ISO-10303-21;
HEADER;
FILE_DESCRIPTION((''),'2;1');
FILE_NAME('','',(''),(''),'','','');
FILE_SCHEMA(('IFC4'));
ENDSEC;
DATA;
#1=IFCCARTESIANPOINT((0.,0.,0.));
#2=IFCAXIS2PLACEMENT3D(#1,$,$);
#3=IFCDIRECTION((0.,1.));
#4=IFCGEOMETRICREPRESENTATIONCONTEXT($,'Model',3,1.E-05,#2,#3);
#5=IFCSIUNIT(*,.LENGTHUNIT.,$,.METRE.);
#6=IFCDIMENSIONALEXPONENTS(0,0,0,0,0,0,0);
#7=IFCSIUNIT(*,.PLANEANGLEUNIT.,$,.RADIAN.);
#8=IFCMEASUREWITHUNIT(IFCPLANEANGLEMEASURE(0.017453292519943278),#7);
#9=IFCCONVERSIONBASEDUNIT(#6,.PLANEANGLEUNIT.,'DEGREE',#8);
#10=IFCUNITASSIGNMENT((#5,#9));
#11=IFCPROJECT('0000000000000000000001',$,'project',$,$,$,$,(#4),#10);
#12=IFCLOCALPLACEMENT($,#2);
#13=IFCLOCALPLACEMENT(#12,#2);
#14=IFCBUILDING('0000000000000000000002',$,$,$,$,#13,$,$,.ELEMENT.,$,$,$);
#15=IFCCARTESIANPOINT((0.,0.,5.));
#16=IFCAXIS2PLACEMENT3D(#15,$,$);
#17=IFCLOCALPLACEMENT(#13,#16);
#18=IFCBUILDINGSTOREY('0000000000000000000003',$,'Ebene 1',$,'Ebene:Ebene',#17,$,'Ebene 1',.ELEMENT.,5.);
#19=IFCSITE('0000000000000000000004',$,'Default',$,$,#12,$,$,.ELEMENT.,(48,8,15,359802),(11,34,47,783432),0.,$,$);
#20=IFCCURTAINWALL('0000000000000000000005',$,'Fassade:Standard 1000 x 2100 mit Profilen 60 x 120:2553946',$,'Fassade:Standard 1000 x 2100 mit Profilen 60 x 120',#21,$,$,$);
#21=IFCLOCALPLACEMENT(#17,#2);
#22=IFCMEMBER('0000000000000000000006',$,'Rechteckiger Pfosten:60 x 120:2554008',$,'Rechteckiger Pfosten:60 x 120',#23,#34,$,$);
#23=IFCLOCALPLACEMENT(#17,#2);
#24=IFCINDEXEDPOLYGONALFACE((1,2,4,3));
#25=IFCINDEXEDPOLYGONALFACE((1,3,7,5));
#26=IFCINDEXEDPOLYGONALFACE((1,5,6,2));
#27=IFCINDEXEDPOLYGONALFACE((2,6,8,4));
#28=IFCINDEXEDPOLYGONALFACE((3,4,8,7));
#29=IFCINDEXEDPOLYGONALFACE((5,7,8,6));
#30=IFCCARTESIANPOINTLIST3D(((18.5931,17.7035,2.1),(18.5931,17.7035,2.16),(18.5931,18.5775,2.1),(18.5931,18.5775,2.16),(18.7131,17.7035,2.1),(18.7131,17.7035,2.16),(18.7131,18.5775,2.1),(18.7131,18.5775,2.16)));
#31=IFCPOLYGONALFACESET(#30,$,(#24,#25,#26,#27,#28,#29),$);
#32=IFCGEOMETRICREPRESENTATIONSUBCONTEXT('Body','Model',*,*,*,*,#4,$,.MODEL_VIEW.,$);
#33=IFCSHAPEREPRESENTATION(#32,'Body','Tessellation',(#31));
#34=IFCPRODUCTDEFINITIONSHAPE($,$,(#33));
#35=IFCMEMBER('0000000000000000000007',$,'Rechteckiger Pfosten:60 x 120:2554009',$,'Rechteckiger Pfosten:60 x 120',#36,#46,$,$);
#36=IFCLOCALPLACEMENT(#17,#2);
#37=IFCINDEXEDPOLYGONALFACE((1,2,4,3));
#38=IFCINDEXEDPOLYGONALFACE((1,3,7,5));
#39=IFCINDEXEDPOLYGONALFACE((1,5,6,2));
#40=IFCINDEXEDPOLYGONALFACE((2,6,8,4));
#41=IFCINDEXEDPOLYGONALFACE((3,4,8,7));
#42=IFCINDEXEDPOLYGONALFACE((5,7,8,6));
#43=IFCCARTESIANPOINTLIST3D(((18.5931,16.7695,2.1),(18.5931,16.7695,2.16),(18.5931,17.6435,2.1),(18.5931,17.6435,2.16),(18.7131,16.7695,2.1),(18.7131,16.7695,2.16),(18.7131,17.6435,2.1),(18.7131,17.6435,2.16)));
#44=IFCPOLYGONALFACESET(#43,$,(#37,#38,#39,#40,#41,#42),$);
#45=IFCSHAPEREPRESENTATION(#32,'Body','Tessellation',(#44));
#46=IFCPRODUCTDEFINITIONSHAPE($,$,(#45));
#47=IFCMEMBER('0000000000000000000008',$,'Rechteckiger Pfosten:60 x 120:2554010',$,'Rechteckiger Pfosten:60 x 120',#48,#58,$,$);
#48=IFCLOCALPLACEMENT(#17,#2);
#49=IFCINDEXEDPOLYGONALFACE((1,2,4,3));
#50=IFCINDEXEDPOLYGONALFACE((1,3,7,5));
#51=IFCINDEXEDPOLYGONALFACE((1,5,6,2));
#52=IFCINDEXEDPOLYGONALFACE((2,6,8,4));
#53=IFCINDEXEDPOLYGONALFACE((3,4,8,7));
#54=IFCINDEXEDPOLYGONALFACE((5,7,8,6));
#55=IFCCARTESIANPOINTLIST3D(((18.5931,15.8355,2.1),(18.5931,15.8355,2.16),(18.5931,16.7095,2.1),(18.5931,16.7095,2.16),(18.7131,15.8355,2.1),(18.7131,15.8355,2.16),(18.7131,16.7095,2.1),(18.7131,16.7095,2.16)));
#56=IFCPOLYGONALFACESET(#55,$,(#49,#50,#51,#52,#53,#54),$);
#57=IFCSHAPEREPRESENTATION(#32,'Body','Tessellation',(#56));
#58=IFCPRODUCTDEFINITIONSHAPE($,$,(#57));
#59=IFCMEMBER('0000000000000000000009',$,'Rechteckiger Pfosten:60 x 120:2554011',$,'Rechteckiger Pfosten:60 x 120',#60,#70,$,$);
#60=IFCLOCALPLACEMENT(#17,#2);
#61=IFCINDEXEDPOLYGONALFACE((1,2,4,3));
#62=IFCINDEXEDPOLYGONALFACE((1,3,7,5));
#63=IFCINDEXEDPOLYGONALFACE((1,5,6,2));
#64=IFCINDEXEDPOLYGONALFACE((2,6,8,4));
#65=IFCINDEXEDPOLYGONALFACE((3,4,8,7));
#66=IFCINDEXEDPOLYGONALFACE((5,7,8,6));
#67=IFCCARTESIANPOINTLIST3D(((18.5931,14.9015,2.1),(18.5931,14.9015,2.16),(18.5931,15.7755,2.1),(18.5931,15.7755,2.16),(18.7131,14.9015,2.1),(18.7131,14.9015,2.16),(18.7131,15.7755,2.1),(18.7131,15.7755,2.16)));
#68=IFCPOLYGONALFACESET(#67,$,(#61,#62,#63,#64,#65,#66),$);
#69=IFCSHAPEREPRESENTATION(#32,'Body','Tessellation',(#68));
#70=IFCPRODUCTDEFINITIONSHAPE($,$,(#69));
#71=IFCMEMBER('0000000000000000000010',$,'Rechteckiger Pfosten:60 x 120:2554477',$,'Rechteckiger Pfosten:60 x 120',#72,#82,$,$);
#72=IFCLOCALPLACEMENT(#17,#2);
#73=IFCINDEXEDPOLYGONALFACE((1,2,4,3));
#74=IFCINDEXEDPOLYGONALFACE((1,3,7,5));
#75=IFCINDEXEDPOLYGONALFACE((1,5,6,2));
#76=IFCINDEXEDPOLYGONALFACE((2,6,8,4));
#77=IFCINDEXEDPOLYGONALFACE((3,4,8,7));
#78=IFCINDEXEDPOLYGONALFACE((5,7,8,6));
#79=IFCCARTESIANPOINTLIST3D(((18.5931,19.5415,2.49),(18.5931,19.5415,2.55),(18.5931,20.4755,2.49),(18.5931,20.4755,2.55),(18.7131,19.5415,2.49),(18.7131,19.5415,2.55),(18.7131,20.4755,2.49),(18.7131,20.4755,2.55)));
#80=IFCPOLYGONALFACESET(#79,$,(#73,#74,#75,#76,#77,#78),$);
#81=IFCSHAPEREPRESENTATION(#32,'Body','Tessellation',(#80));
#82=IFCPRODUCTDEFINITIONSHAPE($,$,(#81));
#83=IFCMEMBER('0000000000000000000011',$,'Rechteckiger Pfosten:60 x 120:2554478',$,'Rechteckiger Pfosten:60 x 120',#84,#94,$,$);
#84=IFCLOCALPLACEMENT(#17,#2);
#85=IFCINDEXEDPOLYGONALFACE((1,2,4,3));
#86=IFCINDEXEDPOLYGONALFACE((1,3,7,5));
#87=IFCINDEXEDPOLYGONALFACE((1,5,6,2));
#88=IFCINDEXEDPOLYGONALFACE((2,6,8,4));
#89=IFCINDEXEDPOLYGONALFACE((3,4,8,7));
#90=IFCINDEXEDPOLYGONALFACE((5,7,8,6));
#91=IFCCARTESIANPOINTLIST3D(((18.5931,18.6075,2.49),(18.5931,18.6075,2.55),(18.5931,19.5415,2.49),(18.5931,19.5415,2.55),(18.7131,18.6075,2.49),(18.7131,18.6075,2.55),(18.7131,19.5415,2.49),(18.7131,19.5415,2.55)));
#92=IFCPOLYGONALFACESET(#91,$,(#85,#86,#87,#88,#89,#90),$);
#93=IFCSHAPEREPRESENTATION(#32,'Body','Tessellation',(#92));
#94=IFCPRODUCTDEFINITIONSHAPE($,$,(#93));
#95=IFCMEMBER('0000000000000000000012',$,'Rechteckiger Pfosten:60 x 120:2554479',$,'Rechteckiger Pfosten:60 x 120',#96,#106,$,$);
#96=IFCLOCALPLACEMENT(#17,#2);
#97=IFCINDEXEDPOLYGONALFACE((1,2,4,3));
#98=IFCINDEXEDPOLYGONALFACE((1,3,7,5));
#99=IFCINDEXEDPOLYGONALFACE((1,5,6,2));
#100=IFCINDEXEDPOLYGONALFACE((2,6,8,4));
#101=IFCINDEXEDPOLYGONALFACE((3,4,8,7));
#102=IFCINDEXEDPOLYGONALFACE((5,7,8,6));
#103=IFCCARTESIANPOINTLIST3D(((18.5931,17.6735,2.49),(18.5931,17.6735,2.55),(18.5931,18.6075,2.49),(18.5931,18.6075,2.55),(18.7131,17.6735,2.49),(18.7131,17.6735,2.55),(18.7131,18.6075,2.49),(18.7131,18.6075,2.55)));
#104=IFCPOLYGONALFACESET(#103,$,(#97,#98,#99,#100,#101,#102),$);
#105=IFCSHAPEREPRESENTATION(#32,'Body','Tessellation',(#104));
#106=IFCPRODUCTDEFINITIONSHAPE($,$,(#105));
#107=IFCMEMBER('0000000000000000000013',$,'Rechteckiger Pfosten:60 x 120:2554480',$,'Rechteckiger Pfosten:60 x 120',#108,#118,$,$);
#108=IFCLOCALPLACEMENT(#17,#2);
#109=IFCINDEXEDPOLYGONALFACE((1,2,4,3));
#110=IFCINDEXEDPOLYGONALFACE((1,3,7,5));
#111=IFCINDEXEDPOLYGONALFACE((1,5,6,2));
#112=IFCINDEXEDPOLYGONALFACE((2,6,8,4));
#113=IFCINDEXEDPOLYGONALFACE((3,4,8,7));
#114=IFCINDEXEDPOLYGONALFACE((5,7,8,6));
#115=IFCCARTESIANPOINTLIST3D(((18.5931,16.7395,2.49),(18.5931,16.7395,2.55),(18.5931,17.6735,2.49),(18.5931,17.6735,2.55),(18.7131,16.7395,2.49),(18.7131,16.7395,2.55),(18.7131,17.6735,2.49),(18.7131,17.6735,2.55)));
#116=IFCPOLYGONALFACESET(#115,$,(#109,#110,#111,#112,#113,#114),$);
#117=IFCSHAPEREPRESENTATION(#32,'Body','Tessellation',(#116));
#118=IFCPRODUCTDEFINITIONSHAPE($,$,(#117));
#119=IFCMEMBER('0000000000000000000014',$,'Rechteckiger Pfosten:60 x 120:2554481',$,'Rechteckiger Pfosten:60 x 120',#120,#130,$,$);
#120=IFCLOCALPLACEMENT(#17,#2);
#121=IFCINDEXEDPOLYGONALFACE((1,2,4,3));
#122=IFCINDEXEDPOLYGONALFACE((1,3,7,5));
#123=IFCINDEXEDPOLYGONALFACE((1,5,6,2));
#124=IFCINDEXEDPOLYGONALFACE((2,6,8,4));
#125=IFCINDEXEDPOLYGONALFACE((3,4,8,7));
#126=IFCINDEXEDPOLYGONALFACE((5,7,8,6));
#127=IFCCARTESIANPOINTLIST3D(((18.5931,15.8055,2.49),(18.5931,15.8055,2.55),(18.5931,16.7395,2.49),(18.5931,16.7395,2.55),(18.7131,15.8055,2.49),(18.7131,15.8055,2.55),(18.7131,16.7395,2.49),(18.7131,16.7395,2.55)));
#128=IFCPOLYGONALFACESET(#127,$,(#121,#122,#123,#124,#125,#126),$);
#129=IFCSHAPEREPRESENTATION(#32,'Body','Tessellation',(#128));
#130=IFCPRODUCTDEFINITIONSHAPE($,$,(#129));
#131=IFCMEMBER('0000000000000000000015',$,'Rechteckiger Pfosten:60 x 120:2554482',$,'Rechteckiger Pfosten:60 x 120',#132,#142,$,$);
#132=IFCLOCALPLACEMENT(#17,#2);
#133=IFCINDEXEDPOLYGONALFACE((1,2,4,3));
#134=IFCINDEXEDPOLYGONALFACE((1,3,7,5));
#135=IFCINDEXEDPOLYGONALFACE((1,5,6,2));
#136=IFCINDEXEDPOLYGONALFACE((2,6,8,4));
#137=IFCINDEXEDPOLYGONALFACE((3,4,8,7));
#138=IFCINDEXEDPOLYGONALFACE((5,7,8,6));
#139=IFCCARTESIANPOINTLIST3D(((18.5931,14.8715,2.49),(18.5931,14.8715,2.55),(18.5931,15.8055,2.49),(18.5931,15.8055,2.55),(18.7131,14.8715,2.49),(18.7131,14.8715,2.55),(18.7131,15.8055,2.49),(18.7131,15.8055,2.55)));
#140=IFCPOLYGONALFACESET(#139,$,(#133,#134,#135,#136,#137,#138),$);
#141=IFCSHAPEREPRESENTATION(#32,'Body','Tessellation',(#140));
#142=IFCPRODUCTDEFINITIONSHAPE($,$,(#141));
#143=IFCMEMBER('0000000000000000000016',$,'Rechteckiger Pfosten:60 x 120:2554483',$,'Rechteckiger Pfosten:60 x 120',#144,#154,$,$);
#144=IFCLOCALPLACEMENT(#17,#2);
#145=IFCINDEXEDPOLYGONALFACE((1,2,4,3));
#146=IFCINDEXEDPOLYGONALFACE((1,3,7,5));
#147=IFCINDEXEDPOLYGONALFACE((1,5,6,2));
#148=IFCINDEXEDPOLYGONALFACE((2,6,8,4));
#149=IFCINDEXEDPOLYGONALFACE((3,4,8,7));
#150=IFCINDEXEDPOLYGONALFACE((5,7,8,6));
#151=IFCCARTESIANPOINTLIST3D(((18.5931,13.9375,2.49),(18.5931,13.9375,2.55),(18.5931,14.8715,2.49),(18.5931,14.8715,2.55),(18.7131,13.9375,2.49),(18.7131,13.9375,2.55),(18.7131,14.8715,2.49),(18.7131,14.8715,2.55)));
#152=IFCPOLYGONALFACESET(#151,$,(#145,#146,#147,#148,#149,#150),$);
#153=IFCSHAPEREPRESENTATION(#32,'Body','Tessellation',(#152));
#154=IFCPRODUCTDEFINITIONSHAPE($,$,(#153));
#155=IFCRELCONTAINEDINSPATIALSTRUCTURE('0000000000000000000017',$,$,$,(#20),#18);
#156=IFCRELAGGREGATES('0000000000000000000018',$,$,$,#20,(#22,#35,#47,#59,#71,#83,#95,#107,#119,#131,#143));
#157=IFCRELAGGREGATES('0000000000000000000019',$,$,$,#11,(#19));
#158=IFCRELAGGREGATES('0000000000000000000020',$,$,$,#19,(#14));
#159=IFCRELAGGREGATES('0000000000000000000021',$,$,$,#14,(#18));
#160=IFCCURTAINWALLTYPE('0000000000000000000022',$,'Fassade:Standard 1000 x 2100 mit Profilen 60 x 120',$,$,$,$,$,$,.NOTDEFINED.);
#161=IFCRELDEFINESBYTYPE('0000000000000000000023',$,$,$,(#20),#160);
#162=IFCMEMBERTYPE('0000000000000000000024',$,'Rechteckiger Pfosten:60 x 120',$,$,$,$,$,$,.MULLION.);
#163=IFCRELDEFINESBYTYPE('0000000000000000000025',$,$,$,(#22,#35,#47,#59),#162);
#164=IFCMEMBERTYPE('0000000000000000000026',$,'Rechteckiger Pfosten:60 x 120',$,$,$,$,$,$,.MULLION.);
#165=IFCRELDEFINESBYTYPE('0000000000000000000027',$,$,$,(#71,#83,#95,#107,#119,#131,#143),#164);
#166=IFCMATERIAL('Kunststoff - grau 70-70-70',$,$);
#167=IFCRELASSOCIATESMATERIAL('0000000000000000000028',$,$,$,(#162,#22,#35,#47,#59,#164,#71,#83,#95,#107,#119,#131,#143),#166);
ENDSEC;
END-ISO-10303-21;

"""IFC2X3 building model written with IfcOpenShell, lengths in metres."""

from ifc_helpers import new_model, entity, si_unit, converted_unit, direction, frame, frame_2d, origin, origin_2d_with_axis, place, context, subcontext, project, spatial, rectangle, extrude, source, transform, mapped, material, type_object, type_shapes, element, aggregate, save


model = new_model("IFC2X3")

# Units and contexts
model_context = context("Model", 3, precision=1e-05, world=origin(), true_north=direction((0.0, 1.0)))
body_context = subcontext(model_context, "Body", "Model", "MODEL_VIEW")
ifc_project = project(units=[si_unit("LENGTHUNIT", "METRE"), converted_unit("PLANEANGLEUNIT", "DEGREE", entity("IfcPlaneAngleMeasure", 0.017453292519943278), si_unit("PLANEANGLEUNIT", "RADIAN"), dimensions=[0, 0, 0, 0, 0, 0, 0])], contexts=[model_context])

# Site, building, storey
site_placement = place(None, origin())
site = spatial("IfcSite", under=ifc_project, at=site_placement, Name="Default", CompositionType="ELEMENT", RefLatitude=(48, 8, 15, 359802), RefLongitude=(11, 34, 47, 783432), RefElevation=0.0)
building_placement = place(site_placement, origin())
building = spatial("IfcBuilding", under=site, at=building_placement, CompositionType="ELEMENT")
storey_placement = place(building_placement, frame((0.0, 0.0, 5.0)))
storey = spatial("IfcBuildingStorey", under=building, at=storey_placement, Name="Ebene 1", ObjectType="Ebene:Ebene", LongName="Ebene 1", CompositionType="ELEMENT", Elevation=5.0)

# Shared definitions
curtain_wall_type = type_object("IfcCurtainWallType", Name="Fassade:Standard 1000 x 2100 mit Profilen 60 x 120", PredefinedType="NOTDEFINED")
ifc_material_1 = material(Name="Kunststoff - grau 70-70-70")

# Curtain wall
curtain_wall_1_placement = place(storey_placement, frame((0.0, 0.0, -5.0)))
curtain_wall_1 = element("IfcCurtainWall", 1, at=curtain_wall_1_placement, inside=storey, type_object=curtain_wall_type, Name="Fassade:Standard 1000 x 2100 mit Profilen 60 x 120:2553946", ObjectType="Fassade:Standard 1000 x 2100 mit Profilen 60 x 120")

# Members
member_type_1 = type_object("IfcMemberType", Name="Rechteckiger Pfosten:60 x 120", PredefinedType="MULLION", material=ifc_material_1)
shared_shape_1 = source(origin(), body_context, "Body", "SweptSolid", [
    extrude(rectangle(XDim=0.06, YDim=0.12, at=frame_2d((0.0, 0.0), x_axis=(1.0, 0.0))), frame((0.0, 0.0, -0.874), z_axis=(0.0, 0.0, 1.0), x_axis=(-1.0, 0.0, 0.0)), (0.0, 0.0, 1.0), 0.874),
])
type_shapes(member_type_1, [shared_shape_1])
member_1_placement = place(curtain_wall_1_placement, frame((18.6531, 17.7035, 7.13), z_axis=(0.0, -1.0, 0.0), x_axis=(0.0, 0.0, 1.0)))
member_1 = element("IfcMember", 2, at=member_1_placement, type_object=member_type_1, material=ifc_material_1, Name="Rechteckiger Pfosten:60 x 120:2554008", ObjectType="Rechteckiger Pfosten:60 x 120", context=body_context, shape_type="MappedRepresentation", body=[
    mapped(shared_shape_1, transform((0.0, 0.0, 0.0), scale=1.0)),
])
member_2_placement = place(curtain_wall_1_placement, frame((18.6531, 16.7695, 7.13), z_axis=(0.0, -1.0, 0.0), x_axis=(0.0, 0.0, 1.0)))
member_2 = element("IfcMember", 3, at=member_2_placement, type_object=member_type_1, material=ifc_material_1, Name="Rechteckiger Pfosten:60 x 120:2554009", ObjectType="Rechteckiger Pfosten:60 x 120", context=body_context, shape_type="MappedRepresentation", body=[
    mapped(shared_shape_1, transform((0.0, 0.0, 0.0), scale=1.0)),
])
member_3_placement = place(curtain_wall_1_placement, frame((18.6531, 15.8355, 7.13), z_axis=(0.0, -1.0, 0.0), x_axis=(0.0, 0.0, 1.0)))
member_3 = element("IfcMember", 4, at=member_3_placement, type_object=member_type_1, material=ifc_material_1, Name="Rechteckiger Pfosten:60 x 120:2554010", ObjectType="Rechteckiger Pfosten:60 x 120", context=body_context, shape_type="MappedRepresentation", body=[
    mapped(shared_shape_1, transform((0.0, 0.0, 0.0), scale=1.0)),
])
member_4_placement = place(curtain_wall_1_placement, frame((18.6531, 14.9015, 7.13), z_axis=(0.0, -1.0, 0.0), x_axis=(0.0, 0.0, 1.0)))
member_4 = element("IfcMember", 5, at=member_4_placement, type_object=member_type_1, material=ifc_material_1, Name="Rechteckiger Pfosten:60 x 120:2554011", ObjectType="Rechteckiger Pfosten:60 x 120", context=body_context, shape_type="MappedRepresentation", body=[
    mapped(shared_shape_1, transform((0.0, 0.0, 0.0), scale=1.0)),
])
member_type_2 = type_object("IfcMemberType", Name="Rechteckiger Pfosten:60 x 120", PredefinedType="MULLION", material=ifc_material_1)
shared_shape_2 = source(origin(), body_context, "Body", "SweptSolid", [
    extrude(rectangle(XDim=0.06, YDim=0.12, at=origin_2d_with_axis()), frame((-0.03, 0.0, -0.934), z_axis=(0.0, 0.0, 1.0), x_axis=(-1.0, 0.0, 0.0)), (0.0, 0.0, 1.0), 0.934),
])
type_shapes(member_type_2, [shared_shape_2])
member_5_placement = place(curtain_wall_1_placement, frame((18.6531, 19.5415, 7.55), z_axis=(0.0, -1.0, 0.0), x_axis=(0.0, 0.0, 1.0)))
member_5 = element("IfcMember", 6, at=member_5_placement, type_object=member_type_2, material=ifc_material_1, Name="Rechteckiger Pfosten:60 x 120:2554477", ObjectType="Rechteckiger Pfosten:60 x 120", context=body_context, shape_type="MappedRepresentation", body=[
    mapped(shared_shape_2, transform((0.0, 0.0, 0.0), scale=1.0)),
])
member_6_placement = place(curtain_wall_1_placement, frame((18.6531, 18.6075, 7.55), z_axis=(0.0, -1.0, 0.0), x_axis=(0.0, 0.0, 1.0)))
member_6 = element("IfcMember", 7, at=member_6_placement, type_object=member_type_2, material=ifc_material_1, Name="Rechteckiger Pfosten:60 x 120:2554478", ObjectType="Rechteckiger Pfosten:60 x 120", context=body_context, shape_type="MappedRepresentation", body=[
    mapped(shared_shape_2, transform((0.0, 0.0, 0.0), scale=1.0)),
])
member_7_placement = place(curtain_wall_1_placement, frame((18.6531, 17.6735, 7.55), z_axis=(0.0, -1.0, 0.0), x_axis=(0.0, 0.0, 1.0)))
member_7 = element("IfcMember", 8, at=member_7_placement, type_object=member_type_2, material=ifc_material_1, Name="Rechteckiger Pfosten:60 x 120:2554479", ObjectType="Rechteckiger Pfosten:60 x 120", context=body_context, shape_type="MappedRepresentation", body=[
    mapped(shared_shape_2, transform((0.0, 0.0, 0.0), scale=1.0)),
])
member_8_placement = place(curtain_wall_1_placement, frame((18.6531, 16.7395, 7.55), z_axis=(0.0, -1.0, 0.0), x_axis=(0.0, 0.0, 1.0)))
member_8 = element("IfcMember", 9, at=member_8_placement, type_object=member_type_2, material=ifc_material_1, Name="Rechteckiger Pfosten:60 x 120:2554480", ObjectType="Rechteckiger Pfosten:60 x 120", context=body_context, shape_type="MappedRepresentation", body=[
    mapped(shared_shape_2, transform((0.0, 0.0, 0.0), scale=1.0)),
])
member_9_placement = place(curtain_wall_1_placement, frame((18.6531, 15.8055, 7.55), z_axis=(0.0, -1.0, 0.0), x_axis=(0.0, 0.0, 1.0)))
member_9 = element("IfcMember", 10, at=member_9_placement, type_object=member_type_2, material=ifc_material_1, Name="Rechteckiger Pfosten:60 x 120:2554481", ObjectType="Rechteckiger Pfosten:60 x 120", context=body_context, shape_type="MappedRepresentation", body=[
    mapped(shared_shape_2, transform((0.0, 0.0, 0.0), scale=1.0)),
])
member_10_placement = place(curtain_wall_1_placement, frame((18.6531, 14.8715, 7.55), z_axis=(0.0, -1.0, 0.0), x_axis=(0.0, 0.0, 1.0)))
member_10 = element("IfcMember", 11, at=member_10_placement, type_object=member_type_2, material=ifc_material_1, Name="Rechteckiger Pfosten:60 x 120:2554482", ObjectType="Rechteckiger Pfosten:60 x 120", context=body_context, shape_type="MappedRepresentation", body=[
    mapped(shared_shape_2, transform((0.0, 0.0, 0.0), scale=1.0)),
])
member_11_placement = place(curtain_wall_1_placement, frame((18.6531, 13.9375, 7.55), z_axis=(0.0, -1.0, 0.0), x_axis=(0.0, 0.0, 1.0)))
member_11 = element("IfcMember", 12, at=member_11_placement, type_object=member_type_2, material=ifc_material_1, Name="Rechteckiger Pfosten:60 x 120:2554483", ObjectType="Rechteckiger Pfosten:60 x 120", context=body_context, shape_type="MappedRepresentation", body=[
    mapped(shared_shape_2, transform((0.0, 0.0, 0.0), scale=1.0)),
])

aggregate(curtain_wall_1, [member_1, member_2, member_3, member_4, member_5, member_6, member_7, member_8, member_9, member_10, member_11])

save(model, "model.ifc")
